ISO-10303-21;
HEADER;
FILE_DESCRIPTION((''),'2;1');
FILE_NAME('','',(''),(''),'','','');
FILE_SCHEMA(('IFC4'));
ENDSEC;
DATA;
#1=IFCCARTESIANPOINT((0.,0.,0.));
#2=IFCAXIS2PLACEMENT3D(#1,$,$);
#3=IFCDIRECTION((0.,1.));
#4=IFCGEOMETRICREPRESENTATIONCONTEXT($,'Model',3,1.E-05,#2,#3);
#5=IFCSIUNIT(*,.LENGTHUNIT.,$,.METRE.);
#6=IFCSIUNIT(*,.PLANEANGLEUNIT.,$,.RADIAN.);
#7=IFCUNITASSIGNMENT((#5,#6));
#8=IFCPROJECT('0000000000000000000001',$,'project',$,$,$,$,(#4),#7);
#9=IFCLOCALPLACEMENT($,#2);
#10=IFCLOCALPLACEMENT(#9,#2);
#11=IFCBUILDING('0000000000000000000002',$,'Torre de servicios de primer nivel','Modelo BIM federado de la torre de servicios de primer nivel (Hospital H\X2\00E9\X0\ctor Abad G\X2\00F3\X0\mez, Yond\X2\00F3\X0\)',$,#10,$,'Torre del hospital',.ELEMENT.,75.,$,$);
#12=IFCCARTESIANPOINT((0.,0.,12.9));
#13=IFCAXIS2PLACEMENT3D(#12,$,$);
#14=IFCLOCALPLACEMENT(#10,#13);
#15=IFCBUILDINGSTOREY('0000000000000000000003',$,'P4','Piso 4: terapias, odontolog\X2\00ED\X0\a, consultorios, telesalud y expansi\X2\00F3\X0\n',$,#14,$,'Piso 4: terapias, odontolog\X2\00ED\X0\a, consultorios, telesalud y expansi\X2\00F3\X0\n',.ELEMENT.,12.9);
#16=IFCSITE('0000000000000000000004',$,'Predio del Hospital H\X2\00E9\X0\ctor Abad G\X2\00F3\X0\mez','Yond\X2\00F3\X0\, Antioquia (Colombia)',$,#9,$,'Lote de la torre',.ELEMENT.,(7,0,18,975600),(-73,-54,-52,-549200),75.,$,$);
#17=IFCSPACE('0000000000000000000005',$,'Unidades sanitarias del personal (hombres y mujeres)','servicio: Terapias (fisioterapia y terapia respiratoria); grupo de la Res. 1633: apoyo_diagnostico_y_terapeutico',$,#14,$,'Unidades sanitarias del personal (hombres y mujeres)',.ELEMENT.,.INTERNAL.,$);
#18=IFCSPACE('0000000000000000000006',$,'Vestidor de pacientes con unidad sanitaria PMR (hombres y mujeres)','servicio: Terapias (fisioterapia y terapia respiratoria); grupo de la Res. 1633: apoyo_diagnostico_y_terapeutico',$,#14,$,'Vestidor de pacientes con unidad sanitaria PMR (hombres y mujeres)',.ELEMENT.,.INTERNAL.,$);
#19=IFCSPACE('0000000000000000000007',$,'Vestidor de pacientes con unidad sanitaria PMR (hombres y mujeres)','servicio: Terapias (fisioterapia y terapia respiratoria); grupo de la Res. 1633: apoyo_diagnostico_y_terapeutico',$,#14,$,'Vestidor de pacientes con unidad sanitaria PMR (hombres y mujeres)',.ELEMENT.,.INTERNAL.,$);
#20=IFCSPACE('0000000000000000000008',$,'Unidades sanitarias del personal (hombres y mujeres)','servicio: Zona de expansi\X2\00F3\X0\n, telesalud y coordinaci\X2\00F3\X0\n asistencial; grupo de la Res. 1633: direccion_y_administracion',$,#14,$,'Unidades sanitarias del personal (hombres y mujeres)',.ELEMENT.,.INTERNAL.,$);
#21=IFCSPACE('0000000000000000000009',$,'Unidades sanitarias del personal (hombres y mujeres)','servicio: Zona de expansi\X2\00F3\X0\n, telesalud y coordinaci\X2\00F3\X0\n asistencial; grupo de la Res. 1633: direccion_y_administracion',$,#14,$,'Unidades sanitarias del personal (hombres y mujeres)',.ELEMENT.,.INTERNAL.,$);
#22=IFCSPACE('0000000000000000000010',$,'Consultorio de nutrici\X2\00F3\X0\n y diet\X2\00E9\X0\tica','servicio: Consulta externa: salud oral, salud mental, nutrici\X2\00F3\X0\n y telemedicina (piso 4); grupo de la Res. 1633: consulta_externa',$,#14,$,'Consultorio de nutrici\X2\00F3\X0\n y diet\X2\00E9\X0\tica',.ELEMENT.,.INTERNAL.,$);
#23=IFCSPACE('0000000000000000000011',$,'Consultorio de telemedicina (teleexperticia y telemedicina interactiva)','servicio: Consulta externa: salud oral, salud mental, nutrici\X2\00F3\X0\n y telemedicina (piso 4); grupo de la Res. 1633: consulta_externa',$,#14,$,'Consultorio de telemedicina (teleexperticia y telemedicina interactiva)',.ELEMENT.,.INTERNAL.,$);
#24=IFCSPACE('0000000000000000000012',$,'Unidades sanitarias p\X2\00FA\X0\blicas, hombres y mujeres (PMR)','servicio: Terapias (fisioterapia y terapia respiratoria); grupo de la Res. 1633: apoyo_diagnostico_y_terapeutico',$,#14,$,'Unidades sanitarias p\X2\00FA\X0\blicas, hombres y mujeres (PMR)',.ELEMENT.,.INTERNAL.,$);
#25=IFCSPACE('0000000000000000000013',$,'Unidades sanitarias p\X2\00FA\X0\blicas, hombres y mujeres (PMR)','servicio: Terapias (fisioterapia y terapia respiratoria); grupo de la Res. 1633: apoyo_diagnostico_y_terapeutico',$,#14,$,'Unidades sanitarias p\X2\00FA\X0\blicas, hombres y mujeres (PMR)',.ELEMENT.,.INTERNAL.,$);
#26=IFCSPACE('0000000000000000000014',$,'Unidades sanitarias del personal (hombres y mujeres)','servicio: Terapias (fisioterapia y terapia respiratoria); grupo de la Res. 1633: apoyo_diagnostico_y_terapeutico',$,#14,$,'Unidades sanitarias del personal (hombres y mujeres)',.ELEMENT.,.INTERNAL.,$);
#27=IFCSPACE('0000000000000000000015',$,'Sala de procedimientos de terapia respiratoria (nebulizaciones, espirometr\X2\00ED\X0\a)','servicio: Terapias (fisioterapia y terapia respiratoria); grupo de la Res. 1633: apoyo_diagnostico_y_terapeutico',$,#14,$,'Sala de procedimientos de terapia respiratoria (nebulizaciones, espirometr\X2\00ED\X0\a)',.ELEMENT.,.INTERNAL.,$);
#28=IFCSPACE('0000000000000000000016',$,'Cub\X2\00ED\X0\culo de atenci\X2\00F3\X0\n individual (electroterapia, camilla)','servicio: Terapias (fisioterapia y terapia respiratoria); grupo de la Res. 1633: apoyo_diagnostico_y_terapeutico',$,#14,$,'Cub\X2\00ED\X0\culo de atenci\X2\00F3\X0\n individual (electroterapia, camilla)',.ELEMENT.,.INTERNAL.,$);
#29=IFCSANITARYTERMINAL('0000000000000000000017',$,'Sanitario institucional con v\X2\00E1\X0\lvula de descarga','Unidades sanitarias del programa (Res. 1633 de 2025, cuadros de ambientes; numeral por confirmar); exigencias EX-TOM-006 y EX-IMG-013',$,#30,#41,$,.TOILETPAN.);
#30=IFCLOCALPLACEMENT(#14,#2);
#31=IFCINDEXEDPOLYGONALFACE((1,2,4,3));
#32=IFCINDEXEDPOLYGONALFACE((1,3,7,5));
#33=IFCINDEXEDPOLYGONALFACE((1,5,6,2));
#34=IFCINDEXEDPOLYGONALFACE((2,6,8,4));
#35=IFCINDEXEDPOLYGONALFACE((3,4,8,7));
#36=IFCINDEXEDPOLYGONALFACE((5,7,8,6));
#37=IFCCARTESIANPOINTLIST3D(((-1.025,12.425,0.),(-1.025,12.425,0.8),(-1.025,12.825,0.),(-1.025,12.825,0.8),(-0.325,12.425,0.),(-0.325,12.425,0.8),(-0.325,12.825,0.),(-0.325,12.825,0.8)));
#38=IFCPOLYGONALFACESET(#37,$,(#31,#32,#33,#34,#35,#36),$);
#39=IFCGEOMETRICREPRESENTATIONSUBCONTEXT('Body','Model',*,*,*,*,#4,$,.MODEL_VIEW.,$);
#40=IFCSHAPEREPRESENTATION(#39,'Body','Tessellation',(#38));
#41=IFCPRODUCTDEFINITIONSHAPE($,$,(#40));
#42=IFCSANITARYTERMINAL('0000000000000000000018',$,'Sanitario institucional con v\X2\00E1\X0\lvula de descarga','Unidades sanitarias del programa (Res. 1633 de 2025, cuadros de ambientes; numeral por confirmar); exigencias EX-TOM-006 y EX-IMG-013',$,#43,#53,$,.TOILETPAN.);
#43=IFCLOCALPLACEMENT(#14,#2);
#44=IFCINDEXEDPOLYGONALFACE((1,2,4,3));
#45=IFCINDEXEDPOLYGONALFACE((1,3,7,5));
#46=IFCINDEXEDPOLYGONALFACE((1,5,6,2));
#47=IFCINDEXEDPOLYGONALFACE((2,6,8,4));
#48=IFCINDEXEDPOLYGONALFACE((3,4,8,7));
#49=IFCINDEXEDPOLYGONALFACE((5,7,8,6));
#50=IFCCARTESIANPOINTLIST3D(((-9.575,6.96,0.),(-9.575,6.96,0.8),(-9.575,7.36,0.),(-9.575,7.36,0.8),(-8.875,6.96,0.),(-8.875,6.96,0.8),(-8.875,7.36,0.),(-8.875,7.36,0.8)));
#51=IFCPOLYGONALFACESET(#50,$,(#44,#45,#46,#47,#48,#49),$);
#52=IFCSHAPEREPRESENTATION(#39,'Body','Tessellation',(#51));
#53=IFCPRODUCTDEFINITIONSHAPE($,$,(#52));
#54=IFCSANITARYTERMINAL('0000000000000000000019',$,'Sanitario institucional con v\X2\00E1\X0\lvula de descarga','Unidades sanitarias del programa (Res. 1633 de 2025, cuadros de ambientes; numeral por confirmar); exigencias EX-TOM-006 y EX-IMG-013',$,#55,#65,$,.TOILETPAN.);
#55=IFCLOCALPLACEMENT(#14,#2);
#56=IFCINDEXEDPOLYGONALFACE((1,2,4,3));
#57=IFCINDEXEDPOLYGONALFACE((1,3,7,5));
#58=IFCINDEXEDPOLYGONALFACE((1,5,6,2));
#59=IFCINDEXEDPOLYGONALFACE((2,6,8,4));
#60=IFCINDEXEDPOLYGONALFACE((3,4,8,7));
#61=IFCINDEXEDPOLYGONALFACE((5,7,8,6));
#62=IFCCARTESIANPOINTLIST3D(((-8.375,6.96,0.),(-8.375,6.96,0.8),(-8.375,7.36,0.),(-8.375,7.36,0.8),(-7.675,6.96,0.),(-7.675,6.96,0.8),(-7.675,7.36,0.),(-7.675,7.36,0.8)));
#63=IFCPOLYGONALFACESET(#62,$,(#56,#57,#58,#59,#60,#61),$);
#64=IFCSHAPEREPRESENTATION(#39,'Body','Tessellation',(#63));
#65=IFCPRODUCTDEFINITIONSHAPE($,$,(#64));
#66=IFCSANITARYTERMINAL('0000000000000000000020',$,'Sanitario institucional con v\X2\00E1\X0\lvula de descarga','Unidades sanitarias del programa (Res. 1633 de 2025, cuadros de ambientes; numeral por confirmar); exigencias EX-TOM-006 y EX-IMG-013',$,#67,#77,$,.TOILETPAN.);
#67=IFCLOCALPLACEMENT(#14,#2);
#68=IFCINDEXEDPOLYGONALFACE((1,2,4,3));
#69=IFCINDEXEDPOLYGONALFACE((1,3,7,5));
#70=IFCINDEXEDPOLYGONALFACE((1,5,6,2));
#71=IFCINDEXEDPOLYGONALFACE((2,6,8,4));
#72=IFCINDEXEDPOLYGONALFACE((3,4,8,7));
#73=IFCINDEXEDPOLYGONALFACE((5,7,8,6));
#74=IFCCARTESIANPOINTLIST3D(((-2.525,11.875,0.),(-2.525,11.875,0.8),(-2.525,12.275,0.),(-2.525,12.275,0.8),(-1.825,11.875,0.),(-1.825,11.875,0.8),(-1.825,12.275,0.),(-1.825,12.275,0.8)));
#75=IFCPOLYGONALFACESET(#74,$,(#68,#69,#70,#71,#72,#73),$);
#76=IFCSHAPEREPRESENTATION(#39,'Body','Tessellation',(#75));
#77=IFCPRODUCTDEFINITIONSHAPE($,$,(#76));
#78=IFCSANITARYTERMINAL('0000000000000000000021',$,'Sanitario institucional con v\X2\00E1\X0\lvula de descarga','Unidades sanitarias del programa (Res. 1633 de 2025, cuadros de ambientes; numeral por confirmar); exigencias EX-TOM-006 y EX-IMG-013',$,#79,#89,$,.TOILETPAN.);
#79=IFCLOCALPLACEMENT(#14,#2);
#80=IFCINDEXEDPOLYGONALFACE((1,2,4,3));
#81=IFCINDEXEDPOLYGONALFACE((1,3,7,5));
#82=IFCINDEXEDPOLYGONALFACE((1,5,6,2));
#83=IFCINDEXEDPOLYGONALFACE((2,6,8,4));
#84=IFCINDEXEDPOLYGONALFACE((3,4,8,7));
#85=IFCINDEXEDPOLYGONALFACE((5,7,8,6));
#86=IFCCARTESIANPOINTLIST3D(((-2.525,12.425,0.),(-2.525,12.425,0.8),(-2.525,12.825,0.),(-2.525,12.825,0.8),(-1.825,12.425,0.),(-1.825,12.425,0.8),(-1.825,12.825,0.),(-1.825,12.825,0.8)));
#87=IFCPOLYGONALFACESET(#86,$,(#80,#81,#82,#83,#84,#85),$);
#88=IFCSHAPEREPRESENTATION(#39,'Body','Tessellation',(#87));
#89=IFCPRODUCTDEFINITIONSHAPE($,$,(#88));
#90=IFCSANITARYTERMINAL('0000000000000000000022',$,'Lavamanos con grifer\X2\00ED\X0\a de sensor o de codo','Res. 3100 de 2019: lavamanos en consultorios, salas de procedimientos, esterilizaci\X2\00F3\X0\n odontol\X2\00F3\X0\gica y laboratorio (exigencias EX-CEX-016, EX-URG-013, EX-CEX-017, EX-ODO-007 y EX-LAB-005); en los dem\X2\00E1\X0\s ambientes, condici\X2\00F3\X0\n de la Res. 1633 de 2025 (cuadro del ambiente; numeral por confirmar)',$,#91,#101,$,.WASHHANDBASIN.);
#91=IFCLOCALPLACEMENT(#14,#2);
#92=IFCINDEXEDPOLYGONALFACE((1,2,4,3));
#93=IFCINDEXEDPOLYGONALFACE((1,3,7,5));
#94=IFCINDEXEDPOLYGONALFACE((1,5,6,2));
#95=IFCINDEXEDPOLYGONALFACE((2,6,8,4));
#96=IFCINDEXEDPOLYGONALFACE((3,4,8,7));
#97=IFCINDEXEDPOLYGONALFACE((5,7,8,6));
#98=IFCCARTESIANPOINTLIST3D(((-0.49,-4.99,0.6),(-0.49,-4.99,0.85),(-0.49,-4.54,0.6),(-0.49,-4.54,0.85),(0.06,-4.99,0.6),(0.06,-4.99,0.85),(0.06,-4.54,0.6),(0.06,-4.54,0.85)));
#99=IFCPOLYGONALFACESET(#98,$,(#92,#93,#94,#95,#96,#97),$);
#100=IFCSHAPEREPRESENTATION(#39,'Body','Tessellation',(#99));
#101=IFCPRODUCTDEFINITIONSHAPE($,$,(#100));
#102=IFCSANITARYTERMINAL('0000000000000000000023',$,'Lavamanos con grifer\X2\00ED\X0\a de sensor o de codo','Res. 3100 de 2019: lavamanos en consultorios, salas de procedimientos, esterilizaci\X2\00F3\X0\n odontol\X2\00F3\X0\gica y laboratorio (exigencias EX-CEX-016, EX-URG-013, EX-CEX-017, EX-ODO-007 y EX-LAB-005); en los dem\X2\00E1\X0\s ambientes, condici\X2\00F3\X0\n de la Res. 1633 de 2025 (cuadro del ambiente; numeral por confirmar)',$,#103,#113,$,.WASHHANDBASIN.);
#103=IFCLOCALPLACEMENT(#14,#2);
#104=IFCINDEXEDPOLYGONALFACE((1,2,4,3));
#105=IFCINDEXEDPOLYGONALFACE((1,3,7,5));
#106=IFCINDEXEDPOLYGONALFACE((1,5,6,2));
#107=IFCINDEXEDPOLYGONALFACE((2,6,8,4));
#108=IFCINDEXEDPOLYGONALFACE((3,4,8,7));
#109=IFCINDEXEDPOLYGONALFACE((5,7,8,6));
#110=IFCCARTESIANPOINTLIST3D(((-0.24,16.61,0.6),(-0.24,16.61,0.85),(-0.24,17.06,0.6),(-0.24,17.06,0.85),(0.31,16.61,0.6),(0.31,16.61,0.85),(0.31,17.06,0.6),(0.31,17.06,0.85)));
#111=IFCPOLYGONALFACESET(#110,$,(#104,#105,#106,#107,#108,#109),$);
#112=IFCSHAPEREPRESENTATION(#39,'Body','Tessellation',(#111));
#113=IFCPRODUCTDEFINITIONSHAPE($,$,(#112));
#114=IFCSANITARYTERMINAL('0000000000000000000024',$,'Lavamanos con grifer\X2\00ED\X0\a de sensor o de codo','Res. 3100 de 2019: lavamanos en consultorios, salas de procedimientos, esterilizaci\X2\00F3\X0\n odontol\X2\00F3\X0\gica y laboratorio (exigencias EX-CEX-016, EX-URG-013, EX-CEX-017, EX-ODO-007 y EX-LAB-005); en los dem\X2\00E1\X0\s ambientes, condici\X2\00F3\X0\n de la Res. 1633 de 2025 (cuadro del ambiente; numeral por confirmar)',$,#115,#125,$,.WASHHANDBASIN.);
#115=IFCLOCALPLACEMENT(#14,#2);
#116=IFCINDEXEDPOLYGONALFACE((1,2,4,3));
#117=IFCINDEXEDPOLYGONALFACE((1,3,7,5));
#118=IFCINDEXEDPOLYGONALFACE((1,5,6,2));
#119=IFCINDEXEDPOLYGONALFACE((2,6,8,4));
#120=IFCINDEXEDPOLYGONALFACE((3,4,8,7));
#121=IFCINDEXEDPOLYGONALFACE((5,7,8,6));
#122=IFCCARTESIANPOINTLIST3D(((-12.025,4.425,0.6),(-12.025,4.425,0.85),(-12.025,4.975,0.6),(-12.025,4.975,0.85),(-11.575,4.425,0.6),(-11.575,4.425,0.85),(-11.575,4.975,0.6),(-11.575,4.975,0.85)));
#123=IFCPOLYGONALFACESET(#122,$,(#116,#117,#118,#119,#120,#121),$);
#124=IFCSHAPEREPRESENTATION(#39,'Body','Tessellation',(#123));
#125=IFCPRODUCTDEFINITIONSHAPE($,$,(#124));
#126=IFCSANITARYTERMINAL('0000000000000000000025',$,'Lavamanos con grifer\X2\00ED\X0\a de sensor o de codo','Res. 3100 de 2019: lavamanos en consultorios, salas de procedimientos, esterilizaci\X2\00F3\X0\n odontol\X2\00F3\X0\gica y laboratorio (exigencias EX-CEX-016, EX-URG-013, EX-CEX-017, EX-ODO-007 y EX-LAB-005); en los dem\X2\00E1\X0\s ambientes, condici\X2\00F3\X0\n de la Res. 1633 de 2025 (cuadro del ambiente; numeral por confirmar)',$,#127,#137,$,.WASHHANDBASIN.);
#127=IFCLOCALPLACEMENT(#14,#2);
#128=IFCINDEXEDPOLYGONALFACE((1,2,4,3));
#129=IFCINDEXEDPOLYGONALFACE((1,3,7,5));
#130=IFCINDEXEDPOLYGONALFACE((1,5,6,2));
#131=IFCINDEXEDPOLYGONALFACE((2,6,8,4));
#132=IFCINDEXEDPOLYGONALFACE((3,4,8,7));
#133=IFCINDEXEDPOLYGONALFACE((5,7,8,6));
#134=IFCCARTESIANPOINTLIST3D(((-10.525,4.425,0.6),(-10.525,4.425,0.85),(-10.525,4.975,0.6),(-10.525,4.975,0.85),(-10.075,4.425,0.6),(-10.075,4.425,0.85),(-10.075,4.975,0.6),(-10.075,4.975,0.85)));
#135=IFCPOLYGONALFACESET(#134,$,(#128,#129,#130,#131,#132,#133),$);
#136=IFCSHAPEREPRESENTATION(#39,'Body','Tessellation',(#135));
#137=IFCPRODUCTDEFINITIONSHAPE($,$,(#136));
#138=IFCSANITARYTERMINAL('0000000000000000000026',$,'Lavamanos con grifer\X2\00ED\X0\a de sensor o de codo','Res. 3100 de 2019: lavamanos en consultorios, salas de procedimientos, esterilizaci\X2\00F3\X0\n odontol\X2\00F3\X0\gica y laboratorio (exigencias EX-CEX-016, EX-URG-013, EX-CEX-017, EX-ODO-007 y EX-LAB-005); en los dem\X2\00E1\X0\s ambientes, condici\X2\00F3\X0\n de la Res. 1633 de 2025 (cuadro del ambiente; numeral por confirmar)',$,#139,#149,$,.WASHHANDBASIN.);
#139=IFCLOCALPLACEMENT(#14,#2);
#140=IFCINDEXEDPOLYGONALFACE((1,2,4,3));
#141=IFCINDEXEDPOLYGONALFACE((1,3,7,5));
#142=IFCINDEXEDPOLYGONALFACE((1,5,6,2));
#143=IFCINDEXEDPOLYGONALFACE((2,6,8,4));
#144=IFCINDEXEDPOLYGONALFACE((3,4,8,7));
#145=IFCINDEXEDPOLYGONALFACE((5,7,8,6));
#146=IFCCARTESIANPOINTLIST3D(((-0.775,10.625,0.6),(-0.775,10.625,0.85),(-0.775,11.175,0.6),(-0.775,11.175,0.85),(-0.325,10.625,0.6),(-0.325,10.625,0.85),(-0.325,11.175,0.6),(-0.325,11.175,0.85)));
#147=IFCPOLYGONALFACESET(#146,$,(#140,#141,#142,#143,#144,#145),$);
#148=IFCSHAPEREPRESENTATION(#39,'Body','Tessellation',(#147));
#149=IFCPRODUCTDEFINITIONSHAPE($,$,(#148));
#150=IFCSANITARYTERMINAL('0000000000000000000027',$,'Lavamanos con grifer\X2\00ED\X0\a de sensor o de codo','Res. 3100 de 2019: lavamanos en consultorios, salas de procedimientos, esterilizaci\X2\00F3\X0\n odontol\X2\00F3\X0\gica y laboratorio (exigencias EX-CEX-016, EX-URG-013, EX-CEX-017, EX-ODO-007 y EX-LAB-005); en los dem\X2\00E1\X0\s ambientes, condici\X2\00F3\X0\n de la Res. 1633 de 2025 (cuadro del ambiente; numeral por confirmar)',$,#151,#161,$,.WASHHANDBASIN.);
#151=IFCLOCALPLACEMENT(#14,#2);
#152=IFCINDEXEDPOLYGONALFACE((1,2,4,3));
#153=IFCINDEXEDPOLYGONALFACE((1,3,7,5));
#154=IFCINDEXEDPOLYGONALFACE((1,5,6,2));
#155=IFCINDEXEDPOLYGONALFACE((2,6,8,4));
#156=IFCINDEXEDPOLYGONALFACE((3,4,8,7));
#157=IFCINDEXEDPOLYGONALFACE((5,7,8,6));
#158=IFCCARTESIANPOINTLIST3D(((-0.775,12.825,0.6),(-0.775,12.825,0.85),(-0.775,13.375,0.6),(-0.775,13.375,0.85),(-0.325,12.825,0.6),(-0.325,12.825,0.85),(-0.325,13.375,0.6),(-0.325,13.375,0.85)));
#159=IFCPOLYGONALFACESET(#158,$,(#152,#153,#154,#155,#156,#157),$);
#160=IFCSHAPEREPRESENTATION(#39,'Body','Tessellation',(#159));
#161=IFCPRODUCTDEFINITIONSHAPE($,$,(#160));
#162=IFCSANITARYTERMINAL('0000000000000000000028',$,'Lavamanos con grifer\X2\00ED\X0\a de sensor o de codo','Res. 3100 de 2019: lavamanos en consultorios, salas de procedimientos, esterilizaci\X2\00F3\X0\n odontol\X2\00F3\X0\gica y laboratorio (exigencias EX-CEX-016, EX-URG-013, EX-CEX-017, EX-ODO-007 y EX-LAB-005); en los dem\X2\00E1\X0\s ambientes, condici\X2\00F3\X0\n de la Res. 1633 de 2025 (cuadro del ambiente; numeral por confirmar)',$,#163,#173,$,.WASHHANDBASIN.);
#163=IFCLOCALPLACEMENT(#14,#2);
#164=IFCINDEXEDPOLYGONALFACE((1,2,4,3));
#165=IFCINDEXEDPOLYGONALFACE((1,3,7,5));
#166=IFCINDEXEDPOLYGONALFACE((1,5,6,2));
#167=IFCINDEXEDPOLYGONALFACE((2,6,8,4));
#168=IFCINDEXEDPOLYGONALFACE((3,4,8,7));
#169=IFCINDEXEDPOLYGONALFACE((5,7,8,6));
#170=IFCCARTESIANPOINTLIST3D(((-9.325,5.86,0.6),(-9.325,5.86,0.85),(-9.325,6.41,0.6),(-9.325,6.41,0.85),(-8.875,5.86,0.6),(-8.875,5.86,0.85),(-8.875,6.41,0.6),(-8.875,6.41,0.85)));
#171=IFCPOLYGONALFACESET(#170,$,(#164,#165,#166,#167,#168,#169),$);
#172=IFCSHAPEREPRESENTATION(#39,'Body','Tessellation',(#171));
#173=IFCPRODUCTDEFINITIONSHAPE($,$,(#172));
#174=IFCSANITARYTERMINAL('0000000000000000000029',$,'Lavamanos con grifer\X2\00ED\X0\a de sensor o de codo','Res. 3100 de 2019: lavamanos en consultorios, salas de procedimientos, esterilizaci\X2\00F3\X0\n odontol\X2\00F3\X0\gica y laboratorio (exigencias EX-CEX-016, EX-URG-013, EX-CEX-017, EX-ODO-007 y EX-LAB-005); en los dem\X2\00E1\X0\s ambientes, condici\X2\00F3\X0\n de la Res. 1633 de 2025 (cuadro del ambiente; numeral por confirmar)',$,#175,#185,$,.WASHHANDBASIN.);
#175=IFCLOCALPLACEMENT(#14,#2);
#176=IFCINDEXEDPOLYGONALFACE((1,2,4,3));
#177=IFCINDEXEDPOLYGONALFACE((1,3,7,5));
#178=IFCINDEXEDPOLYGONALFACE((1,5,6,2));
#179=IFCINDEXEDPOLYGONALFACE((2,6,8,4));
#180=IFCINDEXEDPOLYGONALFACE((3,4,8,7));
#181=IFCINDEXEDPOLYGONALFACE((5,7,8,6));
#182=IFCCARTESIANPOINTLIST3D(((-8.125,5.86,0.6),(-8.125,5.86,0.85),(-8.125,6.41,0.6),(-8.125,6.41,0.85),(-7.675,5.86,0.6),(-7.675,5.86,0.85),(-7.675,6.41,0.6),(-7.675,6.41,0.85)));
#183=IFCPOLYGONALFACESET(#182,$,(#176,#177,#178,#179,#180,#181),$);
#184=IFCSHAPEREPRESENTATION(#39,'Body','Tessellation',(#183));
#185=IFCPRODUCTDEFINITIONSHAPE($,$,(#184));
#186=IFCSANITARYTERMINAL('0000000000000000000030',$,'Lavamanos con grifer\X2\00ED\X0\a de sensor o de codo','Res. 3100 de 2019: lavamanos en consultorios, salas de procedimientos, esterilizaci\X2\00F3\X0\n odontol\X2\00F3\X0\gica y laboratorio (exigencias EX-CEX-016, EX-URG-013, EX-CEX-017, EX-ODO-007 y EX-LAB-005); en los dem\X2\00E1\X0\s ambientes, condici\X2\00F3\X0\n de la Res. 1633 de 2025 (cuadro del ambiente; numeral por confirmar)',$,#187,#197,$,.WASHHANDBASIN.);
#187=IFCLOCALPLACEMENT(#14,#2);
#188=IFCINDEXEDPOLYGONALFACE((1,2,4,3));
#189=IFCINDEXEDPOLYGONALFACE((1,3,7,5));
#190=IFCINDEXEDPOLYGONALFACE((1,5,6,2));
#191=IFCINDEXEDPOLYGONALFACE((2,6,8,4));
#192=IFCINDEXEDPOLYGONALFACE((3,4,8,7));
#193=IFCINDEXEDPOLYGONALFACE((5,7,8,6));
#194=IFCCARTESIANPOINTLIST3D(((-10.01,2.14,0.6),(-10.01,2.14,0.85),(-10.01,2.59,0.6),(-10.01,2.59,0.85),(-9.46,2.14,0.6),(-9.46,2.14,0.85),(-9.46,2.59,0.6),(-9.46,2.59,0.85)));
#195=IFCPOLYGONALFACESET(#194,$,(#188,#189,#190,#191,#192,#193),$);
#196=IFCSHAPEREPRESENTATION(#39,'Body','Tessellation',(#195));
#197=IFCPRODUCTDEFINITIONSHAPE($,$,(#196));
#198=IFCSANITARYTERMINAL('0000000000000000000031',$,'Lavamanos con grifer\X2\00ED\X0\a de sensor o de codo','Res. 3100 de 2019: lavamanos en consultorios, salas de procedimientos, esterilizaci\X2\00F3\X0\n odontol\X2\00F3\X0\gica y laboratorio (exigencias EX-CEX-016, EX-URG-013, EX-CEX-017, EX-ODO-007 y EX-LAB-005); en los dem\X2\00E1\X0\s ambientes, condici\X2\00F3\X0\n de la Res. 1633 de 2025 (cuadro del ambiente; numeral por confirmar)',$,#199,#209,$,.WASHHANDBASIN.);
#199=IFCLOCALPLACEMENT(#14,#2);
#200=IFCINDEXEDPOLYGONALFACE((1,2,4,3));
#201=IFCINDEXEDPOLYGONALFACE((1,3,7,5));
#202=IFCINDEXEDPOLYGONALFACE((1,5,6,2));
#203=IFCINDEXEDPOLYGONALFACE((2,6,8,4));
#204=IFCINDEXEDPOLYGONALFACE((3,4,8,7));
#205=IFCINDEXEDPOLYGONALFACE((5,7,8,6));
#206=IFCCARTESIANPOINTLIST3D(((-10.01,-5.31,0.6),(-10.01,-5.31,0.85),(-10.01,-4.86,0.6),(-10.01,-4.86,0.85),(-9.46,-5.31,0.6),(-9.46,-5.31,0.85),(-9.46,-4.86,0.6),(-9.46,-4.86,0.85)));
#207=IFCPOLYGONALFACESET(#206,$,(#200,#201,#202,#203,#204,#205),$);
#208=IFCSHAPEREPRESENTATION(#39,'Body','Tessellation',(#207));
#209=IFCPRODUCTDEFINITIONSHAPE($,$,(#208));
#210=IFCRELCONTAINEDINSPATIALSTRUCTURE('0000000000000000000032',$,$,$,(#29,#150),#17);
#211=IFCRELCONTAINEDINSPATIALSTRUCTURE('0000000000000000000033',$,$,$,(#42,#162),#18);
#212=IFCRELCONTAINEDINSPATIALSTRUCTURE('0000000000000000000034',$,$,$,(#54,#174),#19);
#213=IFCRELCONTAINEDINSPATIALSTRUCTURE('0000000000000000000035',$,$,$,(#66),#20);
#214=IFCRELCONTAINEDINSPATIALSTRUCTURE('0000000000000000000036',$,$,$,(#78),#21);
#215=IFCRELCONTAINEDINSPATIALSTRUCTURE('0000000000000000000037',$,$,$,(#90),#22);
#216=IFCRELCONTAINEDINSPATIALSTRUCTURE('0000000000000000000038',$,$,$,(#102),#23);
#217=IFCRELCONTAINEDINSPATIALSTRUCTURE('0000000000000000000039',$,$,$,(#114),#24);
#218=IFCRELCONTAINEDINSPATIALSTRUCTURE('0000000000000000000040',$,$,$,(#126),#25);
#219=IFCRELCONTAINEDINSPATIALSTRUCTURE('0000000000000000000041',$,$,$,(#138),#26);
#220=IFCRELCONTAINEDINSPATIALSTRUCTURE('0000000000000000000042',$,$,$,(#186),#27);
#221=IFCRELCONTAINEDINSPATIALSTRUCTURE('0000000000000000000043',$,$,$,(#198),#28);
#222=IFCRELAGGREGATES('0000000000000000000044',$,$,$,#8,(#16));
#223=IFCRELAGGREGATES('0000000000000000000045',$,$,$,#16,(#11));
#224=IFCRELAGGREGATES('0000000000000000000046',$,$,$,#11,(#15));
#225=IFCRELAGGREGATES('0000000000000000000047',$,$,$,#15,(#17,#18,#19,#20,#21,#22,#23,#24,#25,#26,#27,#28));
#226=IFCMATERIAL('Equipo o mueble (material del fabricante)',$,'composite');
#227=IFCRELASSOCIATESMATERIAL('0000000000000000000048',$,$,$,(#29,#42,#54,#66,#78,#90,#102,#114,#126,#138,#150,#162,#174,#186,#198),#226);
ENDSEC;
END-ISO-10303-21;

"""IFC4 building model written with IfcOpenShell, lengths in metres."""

from ifc_helpers import new_model, si_unit, direction, frame, origin, place, context, subcontext, project, spatial, rectangle, extrude, material, element, save


model = new_model("IFC4")

# Units and contexts
model_context = context("Model", 3, precision=1e-05, world=origin(), true_north=direction((0.0, 1.0)))
body_context = subcontext(model_context, "Body", "Model", "MODEL_VIEW")
ifc_project = project(units=[si_unit("LENGTHUNIT", "METRE"), si_unit("PLANEANGLEUNIT", "RADIAN")], contexts=[model_context])

# Site, building, storey, space
site_placement = place(None, origin())
site = spatial("IfcSite", under=ifc_project, at=site_placement, Name="Predio del Hospital Héctor Abad Gómez", Description="Yondó, Antioquia (Colombia)", LongName="Lote de la torre", CompositionType="ELEMENT", RefLatitude=(7, 0, 18, 975600), RefLongitude=(-73, -54, -52, -549200), RefElevation=75.0)
building_placement = place(site_placement, origin())
building = spatial("IfcBuilding", under=site, at=building_placement, Name="Torre de servicios de primer nivel", Description="Modelo BIM federado de la torre de servicios de primer nivel (Hospital Héctor Abad Gómez, Yondó)", LongName="Torre del hospital", CompositionType="ELEMENT", ElevationOfRefHeight=75.0)
placement = place(building_placement, frame((0.0, 0.0, 12.9)))
storey = spatial("IfcBuildingStorey", under=building, at=placement, Name="P4", Description="Piso 4: terapias, odontología, consultorios, telesalud y expansión", LongName="Piso 4: terapias, odontología, consultorios, telesalud y expansión", CompositionType="ELEMENT", Elevation=12.9)
space_1 = spatial("IfcSpace", under=storey, at=placement, Name="Unidades sanitarias del personal (hombres y mujeres)", Description="servicio: Terapias (fisioterapia y terapia respiratoria); grupo de la Res. 1633: apoyo_diagnostico_y_terapeutico", LongName="Unidades sanitarias del personal (hombres y mujeres)", CompositionType="ELEMENT", PredefinedType="INTERNAL")

# Sanitary terminal
ifc_material = material(Name="Equipo o mueble (material del fabricante)", Category="composite")
element("IfcSanitaryTerminal", 1, at=placement, inside=space_1, material=ifc_material, Name="Sanitario institucional con válvula de descarga", Description="Unidades sanitarias del programa (Res. 1633 de 2025, cuadros de ambientes; numeral por confirmar); exigencias EX-TOM-006 y EX-IMG-013", PredefinedType="TOILETPAN", context=body_context, shape_type="SweptSolid", body=[
    extrude(rectangle(XDim=0.4, YDim=0.7), frame((-0.675, 12.625, 0.0), z_axis=(0.0, 0.0, 1.0), x_axis=(0.0, 1.0, 0.0)), (0.0, 0.0, 1.0), 0.8),
])

# Shared definitions
space_2 = spatial("IfcSpace", under=storey, at=placement, Name="Vestidor de pacientes con unidad sanitaria PMR (hombres y mujeres)", Description="servicio: Terapias (fisioterapia y terapia respiratoria); grupo de la Res. 1633: apoyo_diagnostico_y_terapeutico", LongName="Vestidor de pacientes con unidad sanitaria PMR (hombres y mujeres)", CompositionType="ELEMENT", PredefinedType="INTERNAL")

# Sanitary terminal
element("IfcSanitaryTerminal", 2, at=placement, inside=space_2, material=ifc_material, Name="Sanitario institucional con válvula de descarga", Description="Unidades sanitarias del programa (Res. 1633 de 2025, cuadros de ambientes; numeral por confirmar); exigencias EX-TOM-006 y EX-IMG-013", PredefinedType="TOILETPAN", context=body_context, shape_type="SweptSolid", body=[
    extrude(rectangle(XDim=0.4, YDim=0.7), frame((-9.225, 7.16, 0.0), z_axis=(0.0, 0.0, 1.0), x_axis=(0.0, 1.0, 0.0)), (0.0, 0.0, 1.0), 0.8),
])

# Shared definitions
space_3 = spatial("IfcSpace", under=storey, at=placement, Name="Vestidor de pacientes con unidad sanitaria PMR (hombres y mujeres)", Description="servicio: Terapias (fisioterapia y terapia respiratoria); grupo de la Res. 1633: apoyo_diagnostico_y_terapeutico", LongName="Vestidor de pacientes con unidad sanitaria PMR (hombres y mujeres)", CompositionType="ELEMENT", PredefinedType="INTERNAL")

# Sanitary terminal
element("IfcSanitaryTerminal", 3, at=placement, inside=space_3, material=ifc_material, Name="Sanitario institucional con válvula de descarga", Description="Unidades sanitarias del programa (Res. 1633 de 2025, cuadros de ambientes; numeral por confirmar); exigencias EX-TOM-006 y EX-IMG-013", PredefinedType="TOILETPAN", context=body_context, shape_type="SweptSolid", body=[
    extrude(rectangle(XDim=0.4, YDim=0.7), frame((-8.025, 7.16, 0.0), z_axis=(0.0, 0.0, 1.0), x_axis=(0.0, 1.0, 0.0)), (0.0, 0.0, 1.0), 0.8),
])

# Shared definitions
space_4 = spatial("IfcSpace", under=storey, at=placement, Name="Unidades sanitarias del personal (hombres y mujeres)", Description="servicio: Zona de expansión, telesalud y coordinación asistencial; grupo de la Res. 1633: direccion_y_administracion", LongName="Unidades sanitarias del personal (hombres y mujeres)", CompositionType="ELEMENT", PredefinedType="INTERNAL")

# Sanitary terminal
element("IfcSanitaryTerminal", 4, at=placement, inside=space_4, material=ifc_material, Name="Sanitario institucional con válvula de descarga", Description="Unidades sanitarias del programa (Res. 1633 de 2025, cuadros de ambientes; numeral por confirmar); exigencias EX-TOM-006 y EX-IMG-013", PredefinedType="TOILETPAN", context=body_context, shape_type="SweptSolid", body=[
    extrude(rectangle(XDim=0.4, YDim=0.7), frame((-2.175, 12.075, 0.0), z_axis=(0.0, 0.0, 1.0), x_axis=(0.0, 1.0, 0.0)), (0.0, 0.0, 1.0), 0.8),
])

# Shared definitions
space_5 = spatial("IfcSpace", under=storey, at=placement, Name="Unidades sanitarias del personal (hombres y mujeres)", Description="servicio: Zona de expansión, telesalud y coordinación asistencial; grupo de la Res. 1633: direccion_y_administracion", LongName="Unidades sanitarias del personal (hombres y mujeres)", CompositionType="ELEMENT", PredefinedType="INTERNAL")

# Sanitary terminal
element("IfcSanitaryTerminal", 5, at=placement, inside=space_5, material=ifc_material, Name="Sanitario institucional con válvula de descarga", Description="Unidades sanitarias del programa (Res. 1633 de 2025, cuadros de ambientes; numeral por confirmar); exigencias EX-TOM-006 y EX-IMG-013", PredefinedType="TOILETPAN", context=body_context, shape_type="SweptSolid", body=[
    extrude(rectangle(XDim=0.4, YDim=0.7), frame((-2.175, 12.625, 0.0), z_axis=(0.0, 0.0, 1.0), x_axis=(0.0, 1.0, 0.0)), (0.0, 0.0, 1.0), 0.8),
])

# Shared definitions
space_6 = spatial("IfcSpace", under=storey, at=placement, Name="Consultorio de nutrición y dietética", Description="servicio: Consulta externa: salud oral, salud mental, nutrición y telemedicina (piso 4); grupo de la Res. 1633: consulta_externa", LongName="Consultorio de nutrición y dietética", CompositionType="ELEMENT", PredefinedType="INTERNAL")

# Sanitary terminal
element("IfcSanitaryTerminal", 6, at=placement, inside=space_6, material=ifc_material, Name="Lavamanos con grifería de sensor o de codo", Description="Res. 3100 de 2019: lavamanos en consultorios, salas de procedimientos, esterilización odontológica y laboratorio (exigencias EX-CEX-016, EX-URG-013, EX-CEX-017, EX-ODO-007 y EX-LAB-005); en los demás ambientes, condición de la Res. 1633 de 2025 (cuadro del ambiente; numeral por confirmar)", PredefinedType="WASHHANDBASIN", context=body_context, shape_type="SweptSolid", body=[
    extrude(rectangle(XDim=0.55, YDim=0.45), frame((-0.215, -4.765, 0.6)), (0.0, 0.0, 1.0), 0.25),
])

# Shared definitions
space_7 = spatial("IfcSpace", under=storey, at=placement, Name="Consultorio de telemedicina (teleexperticia y telemedicina interactiva)", Description="servicio: Consulta externa: salud oral, salud mental, nutrición y telemedicina (piso 4); grupo de la Res. 1633: consulta_externa", LongName="Consultorio de telemedicina (teleexperticia y telemedicina interactiva)", CompositionType="ELEMENT", PredefinedType="INTERNAL")

# Sanitary terminal
element("IfcSanitaryTerminal", 7, at=placement, inside=space_7, material=ifc_material, Name="Lavamanos con grifería de sensor o de codo", Description="Res. 3100 de 2019: lavamanos en consultorios, salas de procedimientos, esterilización odontológica y laboratorio (exigencias EX-CEX-016, EX-URG-013, EX-CEX-017, EX-ODO-007 y EX-LAB-005); en los demás ambientes, condición de la Res. 1633 de 2025 (cuadro del ambiente; numeral por confirmar)", PredefinedType="WASHHANDBASIN", context=body_context, shape_type="SweptSolid", body=[
    extrude(rectangle(XDim=0.55, YDim=0.45), frame((0.035, 16.835, 0.6)), (0.0, 0.0, 1.0), 0.25),
])

# Shared definitions
space_8 = spatial("IfcSpace", under=storey, at=placement, Name="Unidades sanitarias públicas, hombres y mujeres (PMR)", Description="servicio: Terapias (fisioterapia y terapia respiratoria); grupo de la Res. 1633: apoyo_diagnostico_y_terapeutico", LongName="Unidades sanitarias públicas, hombres y mujeres (PMR)", CompositionType="ELEMENT", PredefinedType="INTERNAL")

# Sanitary terminal
element("IfcSanitaryTerminal", 8, at=placement, inside=space_8, material=ifc_material, Name="Lavamanos con grifería de sensor o de codo", Description="Res. 3100 de 2019: lavamanos en consultorios, salas de procedimientos, esterilización odontológica y laboratorio (exigencias EX-CEX-016, EX-URG-013, EX-CEX-017, EX-ODO-007 y EX-LAB-005); en los demás ambientes, condición de la Res. 1633 de 2025 (cuadro del ambiente; numeral por confirmar)", PredefinedType="WASHHANDBASIN", context=body_context, shape_type="SweptSolid", body=[
    extrude(rectangle(XDim=0.55, YDim=0.45), frame((-11.8, 4.7, 0.6), z_axis=(0.0, 0.0, 1.0), x_axis=(0.0, 1.0, 0.0)), (0.0, 0.0, 1.0), 0.25),
])

# Shared definitions
space_9 = spatial("IfcSpace", under=storey, at=placement, Name="Unidades sanitarias públicas, hombres y mujeres (PMR)", Description="servicio: Terapias (fisioterapia y terapia respiratoria); grupo de la Res. 1633: apoyo_diagnostico_y_terapeutico", LongName="Unidades sanitarias públicas, hombres y mujeres (PMR)", CompositionType="ELEMENT", PredefinedType="INTERNAL")

# Sanitary terminal
element("IfcSanitaryTerminal", 9, at=placement, inside=space_9, material=ifc_material, Name="Lavamanos con grifería de sensor o de codo", Description="Res. 3100 de 2019: lavamanos en consultorios, salas de procedimientos, esterilización odontológica y laboratorio (exigencias EX-CEX-016, EX-URG-013, EX-CEX-017, EX-ODO-007 y EX-LAB-005); en los demás ambientes, condición de la Res. 1633 de 2025 (cuadro del ambiente; numeral por confirmar)", PredefinedType="WASHHANDBASIN", context=body_context, shape_type="SweptSolid", body=[
    extrude(rectangle(XDim=0.55, YDim=0.45), frame((-10.3, 4.7, 0.6), z_axis=(0.0, 0.0, 1.0), x_axis=(0.0, 1.0, 0.0)), (0.0, 0.0, 1.0), 0.25),
])

# Shared definitions
space_10 = spatial("IfcSpace", under=storey, at=placement, Name="Unidades sanitarias del personal (hombres y mujeres)", Description="servicio: Terapias (fisioterapia y terapia respiratoria); grupo de la Res. 1633: apoyo_diagnostico_y_terapeutico", LongName="Unidades sanitarias del personal (hombres y mujeres)", CompositionType="ELEMENT", PredefinedType="INTERNAL")

# Sanitary terminals
element("IfcSanitaryTerminal", 10, at=placement, inside=space_10, material=ifc_material, Name="Lavamanos con grifería de sensor o de codo", Description="Res. 3100 de 2019: lavamanos en consultorios, salas de procedimientos, esterilización odontológica y laboratorio (exigencias EX-CEX-016, EX-URG-013, EX-CEX-017, EX-ODO-007 y EX-LAB-005); en los demás ambientes, condición de la Res. 1633 de 2025 (cuadro del ambiente; numeral por confirmar)", PredefinedType="WASHHANDBASIN", context=body_context, shape_type="SweptSolid", body=[
    extrude(rectangle(XDim=0.55, YDim=0.45), frame((-0.55, 10.9, 0.6), z_axis=(0.0, 0.0, 1.0), x_axis=(0.0, 1.0, 0.0)), (0.0, 0.0, 1.0), 0.25),
])
element("IfcSanitaryTerminal", 11, at=placement, inside=space_1, material=ifc_material, Name="Lavamanos con grifería de sensor o de codo", Description="Res. 3100 de 2019: lavamanos en consultorios, salas de procedimientos, esterilización odontológica y laboratorio (exigencias EX-CEX-016, EX-URG-013, EX-CEX-017, EX-ODO-007 y EX-LAB-005); en los demás ambientes, condición de la Res. 1633 de 2025 (cuadro del ambiente; numeral por confirmar)", PredefinedType="WASHHANDBASIN", context=body_context, shape_type="SweptSolid", body=[
    extrude(rectangle(XDim=0.55, YDim=0.45), frame((-0.55, 13.1, 0.6), z_axis=(0.0, 0.0, 1.0), x_axis=(0.0, 1.0, 0.0)), (0.0, 0.0, 1.0), 0.25),
])
element("IfcSanitaryTerminal", 12, at=placement, inside=space_2, material=ifc_material, Name="Lavamanos con grifería de sensor o de codo", Description="Res. 3100 de 2019: lavamanos en consultorios, salas de procedimientos, esterilización odontológica y laboratorio (exigencias EX-CEX-016, EX-URG-013, EX-CEX-017, EX-ODO-007 y EX-LAB-005); en los demás ambientes, condición de la Res. 1633 de 2025 (cuadro del ambiente; numeral por confirmar)", PredefinedType="WASHHANDBASIN", context=body_context, shape_type="SweptSolid", body=[
    extrude(rectangle(XDim=0.55, YDim=0.45), frame((-9.1, 6.135, 0.6), z_axis=(0.0, 0.0, 1.0), x_axis=(0.0, 1.0, 0.0)), (0.0, 0.0, 1.0), 0.25),
])
element("IfcSanitaryTerminal", 13, at=placement, inside=space_3, material=ifc_material, Name="Lavamanos con grifería de sensor o de codo", Description="Res. 3100 de 2019: lavamanos en consultorios, salas de procedimientos, esterilización odontológica y laboratorio (exigencias EX-CEX-016, EX-URG-013, EX-CEX-017, EX-ODO-007 y EX-LAB-005); en los demás ambientes, condición de la Res. 1633 de 2025 (cuadro del ambiente; numeral por confirmar)", PredefinedType="WASHHANDBASIN", context=body_context, shape_type="SweptSolid", body=[
    extrude(rectangle(XDim=0.55, YDim=0.45), frame((-7.9, 6.135, 0.6), z_axis=(0.0, 0.0, 1.0), x_axis=(0.0, 1.0, 0.0)), (0.0, 0.0, 1.0), 0.25),
])

# Shared definitions
space_11 = spatial("IfcSpace", under=storey, at=placement, Name="Sala de procedimientos de terapia respiratoria (nebulizaciones, espirometría)", Description="servicio: Terapias (fisioterapia y terapia respiratoria); grupo de la Res. 1633: apoyo_diagnostico_y_terapeutico", LongName="Sala de procedimientos de terapia respiratoria (nebulizaciones, espirometría)", CompositionType="ELEMENT", PredefinedType="INTERNAL")

# Sanitary terminal
element("IfcSanitaryTerminal", 14, at=placement, inside=space_11, material=ifc_material, Name="Lavamanos con grifería de sensor o de codo", Description="Res. 3100 de 2019: lavamanos en consultorios, salas de procedimientos, esterilización odontológica y laboratorio (exigencias EX-CEX-016, EX-URG-013, EX-CEX-017, EX-ODO-007 y EX-LAB-005); en los demás ambientes, condición de la Res. 1633 de 2025 (cuadro del ambiente; numeral por confirmar)", PredefinedType="WASHHANDBASIN", context=body_context, shape_type="SweptSolid", body=[
    extrude(rectangle(XDim=0.55, YDim=0.45), frame((-9.735, 2.365, 0.6), z_axis=(0.0, 0.0, 1.0), x_axis=(-1.0, 0.0, 0.0)), (0.0, 0.0, 1.0), 0.25),
])

# Shared definitions
space_12 = spatial("IfcSpace", under=storey, at=placement, Name="Cubículo de atención individual (electroterapia, camilla)", Description="servicio: Terapias (fisioterapia y terapia respiratoria); grupo de la Res. 1633: apoyo_diagnostico_y_terapeutico", LongName="Cubículo de atención individual (electroterapia, camilla)", CompositionType="ELEMENT", PredefinedType="INTERNAL")

# Sanitary terminal
element("IfcSanitaryTerminal", 15, at=placement, inside=space_12, material=ifc_material, Name="Lavamanos con grifería de sensor o de codo", Description="Res. 3100 de 2019: lavamanos en consultorios, salas de procedimientos, esterilización odontológica y laboratorio (exigencias EX-CEX-016, EX-URG-013, EX-CEX-017, EX-ODO-007 y EX-LAB-005); en los demás ambientes, condición de la Res. 1633 de 2025 (cuadro del ambiente; numeral por confirmar)", PredefinedType="WASHHANDBASIN", context=body_context, shape_type="SweptSolid", body=[
    extrude(rectangle(XDim=0.55, YDim=0.45), frame((-9.735, -5.085, 0.6), z_axis=(0.0, 0.0, 1.0), x_axis=(-1.0, 0.0, 0.0)), (0.0, 0.0, 1.0), 0.25),
])

save(model, "model.ifc")
